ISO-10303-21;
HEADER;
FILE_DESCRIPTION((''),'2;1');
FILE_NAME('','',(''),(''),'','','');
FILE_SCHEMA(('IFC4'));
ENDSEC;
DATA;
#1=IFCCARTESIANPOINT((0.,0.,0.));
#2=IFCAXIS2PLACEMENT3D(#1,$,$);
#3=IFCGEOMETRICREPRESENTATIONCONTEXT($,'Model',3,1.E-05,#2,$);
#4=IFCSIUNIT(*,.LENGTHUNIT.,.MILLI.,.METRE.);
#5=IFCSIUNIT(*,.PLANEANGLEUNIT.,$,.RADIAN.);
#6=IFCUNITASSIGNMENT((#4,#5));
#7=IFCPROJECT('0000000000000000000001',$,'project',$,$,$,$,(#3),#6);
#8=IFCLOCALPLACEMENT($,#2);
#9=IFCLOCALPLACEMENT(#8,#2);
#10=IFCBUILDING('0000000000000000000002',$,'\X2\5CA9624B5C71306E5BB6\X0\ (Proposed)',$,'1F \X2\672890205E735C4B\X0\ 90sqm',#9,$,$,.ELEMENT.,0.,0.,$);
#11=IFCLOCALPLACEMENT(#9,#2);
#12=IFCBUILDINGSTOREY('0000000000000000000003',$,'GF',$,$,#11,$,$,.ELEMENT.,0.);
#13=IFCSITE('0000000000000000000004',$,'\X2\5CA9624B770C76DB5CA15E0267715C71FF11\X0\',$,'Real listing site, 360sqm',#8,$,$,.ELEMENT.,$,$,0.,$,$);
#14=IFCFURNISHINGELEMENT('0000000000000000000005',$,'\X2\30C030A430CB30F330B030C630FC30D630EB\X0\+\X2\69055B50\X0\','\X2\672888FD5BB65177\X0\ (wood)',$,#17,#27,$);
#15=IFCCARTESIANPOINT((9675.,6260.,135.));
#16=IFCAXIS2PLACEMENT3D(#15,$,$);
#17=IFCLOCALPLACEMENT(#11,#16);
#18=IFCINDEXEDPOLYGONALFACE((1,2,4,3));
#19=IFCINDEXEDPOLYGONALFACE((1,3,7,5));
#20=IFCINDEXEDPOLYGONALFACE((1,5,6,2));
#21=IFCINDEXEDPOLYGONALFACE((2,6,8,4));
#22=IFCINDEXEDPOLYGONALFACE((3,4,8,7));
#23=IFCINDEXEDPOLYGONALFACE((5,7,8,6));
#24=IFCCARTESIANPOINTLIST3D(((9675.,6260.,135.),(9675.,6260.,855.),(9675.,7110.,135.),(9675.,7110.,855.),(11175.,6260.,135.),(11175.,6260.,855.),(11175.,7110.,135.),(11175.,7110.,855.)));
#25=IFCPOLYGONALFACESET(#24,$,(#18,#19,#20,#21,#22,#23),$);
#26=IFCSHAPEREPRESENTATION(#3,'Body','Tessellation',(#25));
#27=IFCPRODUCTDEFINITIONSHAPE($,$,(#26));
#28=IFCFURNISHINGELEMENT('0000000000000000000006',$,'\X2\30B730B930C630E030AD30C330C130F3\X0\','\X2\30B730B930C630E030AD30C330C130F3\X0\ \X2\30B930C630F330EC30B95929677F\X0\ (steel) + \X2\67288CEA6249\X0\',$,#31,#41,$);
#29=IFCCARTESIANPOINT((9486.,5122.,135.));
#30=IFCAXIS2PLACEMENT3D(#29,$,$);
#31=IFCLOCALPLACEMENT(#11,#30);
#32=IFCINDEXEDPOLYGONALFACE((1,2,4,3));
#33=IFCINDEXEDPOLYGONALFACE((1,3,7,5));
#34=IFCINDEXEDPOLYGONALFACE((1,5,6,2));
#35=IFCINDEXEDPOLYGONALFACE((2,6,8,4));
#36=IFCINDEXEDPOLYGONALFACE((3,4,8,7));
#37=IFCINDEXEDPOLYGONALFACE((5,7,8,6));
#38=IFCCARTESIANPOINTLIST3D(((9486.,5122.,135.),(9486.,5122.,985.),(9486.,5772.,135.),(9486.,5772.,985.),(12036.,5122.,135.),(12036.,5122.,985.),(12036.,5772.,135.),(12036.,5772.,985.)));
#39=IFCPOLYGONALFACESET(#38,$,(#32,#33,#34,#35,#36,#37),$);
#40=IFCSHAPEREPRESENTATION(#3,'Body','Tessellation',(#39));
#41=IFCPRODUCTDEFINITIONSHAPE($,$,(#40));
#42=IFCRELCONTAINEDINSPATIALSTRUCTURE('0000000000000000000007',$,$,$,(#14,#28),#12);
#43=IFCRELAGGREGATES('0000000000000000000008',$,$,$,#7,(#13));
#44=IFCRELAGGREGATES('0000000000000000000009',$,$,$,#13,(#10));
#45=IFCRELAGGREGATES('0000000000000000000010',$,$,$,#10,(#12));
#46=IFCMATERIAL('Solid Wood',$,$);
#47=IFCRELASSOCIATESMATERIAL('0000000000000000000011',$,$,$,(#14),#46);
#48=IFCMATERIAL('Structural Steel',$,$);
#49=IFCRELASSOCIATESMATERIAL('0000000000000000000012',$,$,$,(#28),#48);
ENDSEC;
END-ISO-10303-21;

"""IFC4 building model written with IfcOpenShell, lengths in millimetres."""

from ifc_helpers import new_model, si_unit, frame, frame_2d, origin, place, context, project, spatial, rectangle, extrude, material, element, save


model = new_model("IFC4")

# Units and contexts
model_context = context("Model", 3, precision=1e-05, world=origin())
ifc_project = project(units=[si_unit("LENGTHUNIT", "METRE", prefix="MILLI"), si_unit("PLANEANGLEUNIT", "RADIAN")], contexts=[model_context])

# Site, building, storey
site_placement = place(None, origin())
site = spatial("IfcSite", under=ifc_project, at=site_placement, Name="岩手県盛岡市東山１", ObjectType="Real listing site, 360sqm", CompositionType="ELEMENT", RefElevation=0.0)
building_placement = place(site_placement, origin())
building = spatial("IfcBuilding", under=site, at=building_placement, Name="岩手山の家 (Proposed)", ObjectType="1F 木造平屋 90sqm", CompositionType="ELEMENT", ElevationOfRefHeight=0.0, ElevationOfTerrain=0.0)
storey_placement = place(building_placement, origin())
storey = spatial("IfcBuildingStorey", under=building, at=storey_placement, Name="GF", CompositionType="ELEMENT", Elevation=0.0)

# Shared definitions
ifc_material_1 = material(Name="Solid Wood")

# Shared definitions
ifc_material_2 = material(Name="Structural Steel")

# Furnishing elements
furnishing_1_placement = place(storey_placement, frame((9675.0, 6260.0, 135.0)))
element("IfcFurnishingElement", 1, at=furnishing_1_placement, inside=storey, material=ifc_material_1, Name="ダイニングテーブル+椅子", Description="木製家具 (wood)", context=model_context, shape_type="SweptSolid", body=[
    extrude(rectangle(XDim=1500.0, YDim=850.0, at=frame_2d((750.0, 425.0))), frame((9675.0, 6260.0, 135.0)), (0.0, 0.0, 1.0), 720.0),
])
furnishing_2_placement = place(storey_placement, frame((9486.0, 5122.0, 135.0)))
element("IfcFurnishingElement", 2, at=furnishing_2_placement, inside=storey, material=ifc_material_2, Name="システムキッチン", Description="システムキッチン ステンレス天板 (steel) + 木質扉", context=model_context, shape_type="SweptSolid", body=[
    extrude(rectangle(XDim=2550.0, YDim=650.0, at=frame_2d((1275.0, 325.0))), frame((9486.0, 5122.0, 135.0)), (0.0, 0.0, 1.0), 850.0),
])

save(model, "model.ifc")
